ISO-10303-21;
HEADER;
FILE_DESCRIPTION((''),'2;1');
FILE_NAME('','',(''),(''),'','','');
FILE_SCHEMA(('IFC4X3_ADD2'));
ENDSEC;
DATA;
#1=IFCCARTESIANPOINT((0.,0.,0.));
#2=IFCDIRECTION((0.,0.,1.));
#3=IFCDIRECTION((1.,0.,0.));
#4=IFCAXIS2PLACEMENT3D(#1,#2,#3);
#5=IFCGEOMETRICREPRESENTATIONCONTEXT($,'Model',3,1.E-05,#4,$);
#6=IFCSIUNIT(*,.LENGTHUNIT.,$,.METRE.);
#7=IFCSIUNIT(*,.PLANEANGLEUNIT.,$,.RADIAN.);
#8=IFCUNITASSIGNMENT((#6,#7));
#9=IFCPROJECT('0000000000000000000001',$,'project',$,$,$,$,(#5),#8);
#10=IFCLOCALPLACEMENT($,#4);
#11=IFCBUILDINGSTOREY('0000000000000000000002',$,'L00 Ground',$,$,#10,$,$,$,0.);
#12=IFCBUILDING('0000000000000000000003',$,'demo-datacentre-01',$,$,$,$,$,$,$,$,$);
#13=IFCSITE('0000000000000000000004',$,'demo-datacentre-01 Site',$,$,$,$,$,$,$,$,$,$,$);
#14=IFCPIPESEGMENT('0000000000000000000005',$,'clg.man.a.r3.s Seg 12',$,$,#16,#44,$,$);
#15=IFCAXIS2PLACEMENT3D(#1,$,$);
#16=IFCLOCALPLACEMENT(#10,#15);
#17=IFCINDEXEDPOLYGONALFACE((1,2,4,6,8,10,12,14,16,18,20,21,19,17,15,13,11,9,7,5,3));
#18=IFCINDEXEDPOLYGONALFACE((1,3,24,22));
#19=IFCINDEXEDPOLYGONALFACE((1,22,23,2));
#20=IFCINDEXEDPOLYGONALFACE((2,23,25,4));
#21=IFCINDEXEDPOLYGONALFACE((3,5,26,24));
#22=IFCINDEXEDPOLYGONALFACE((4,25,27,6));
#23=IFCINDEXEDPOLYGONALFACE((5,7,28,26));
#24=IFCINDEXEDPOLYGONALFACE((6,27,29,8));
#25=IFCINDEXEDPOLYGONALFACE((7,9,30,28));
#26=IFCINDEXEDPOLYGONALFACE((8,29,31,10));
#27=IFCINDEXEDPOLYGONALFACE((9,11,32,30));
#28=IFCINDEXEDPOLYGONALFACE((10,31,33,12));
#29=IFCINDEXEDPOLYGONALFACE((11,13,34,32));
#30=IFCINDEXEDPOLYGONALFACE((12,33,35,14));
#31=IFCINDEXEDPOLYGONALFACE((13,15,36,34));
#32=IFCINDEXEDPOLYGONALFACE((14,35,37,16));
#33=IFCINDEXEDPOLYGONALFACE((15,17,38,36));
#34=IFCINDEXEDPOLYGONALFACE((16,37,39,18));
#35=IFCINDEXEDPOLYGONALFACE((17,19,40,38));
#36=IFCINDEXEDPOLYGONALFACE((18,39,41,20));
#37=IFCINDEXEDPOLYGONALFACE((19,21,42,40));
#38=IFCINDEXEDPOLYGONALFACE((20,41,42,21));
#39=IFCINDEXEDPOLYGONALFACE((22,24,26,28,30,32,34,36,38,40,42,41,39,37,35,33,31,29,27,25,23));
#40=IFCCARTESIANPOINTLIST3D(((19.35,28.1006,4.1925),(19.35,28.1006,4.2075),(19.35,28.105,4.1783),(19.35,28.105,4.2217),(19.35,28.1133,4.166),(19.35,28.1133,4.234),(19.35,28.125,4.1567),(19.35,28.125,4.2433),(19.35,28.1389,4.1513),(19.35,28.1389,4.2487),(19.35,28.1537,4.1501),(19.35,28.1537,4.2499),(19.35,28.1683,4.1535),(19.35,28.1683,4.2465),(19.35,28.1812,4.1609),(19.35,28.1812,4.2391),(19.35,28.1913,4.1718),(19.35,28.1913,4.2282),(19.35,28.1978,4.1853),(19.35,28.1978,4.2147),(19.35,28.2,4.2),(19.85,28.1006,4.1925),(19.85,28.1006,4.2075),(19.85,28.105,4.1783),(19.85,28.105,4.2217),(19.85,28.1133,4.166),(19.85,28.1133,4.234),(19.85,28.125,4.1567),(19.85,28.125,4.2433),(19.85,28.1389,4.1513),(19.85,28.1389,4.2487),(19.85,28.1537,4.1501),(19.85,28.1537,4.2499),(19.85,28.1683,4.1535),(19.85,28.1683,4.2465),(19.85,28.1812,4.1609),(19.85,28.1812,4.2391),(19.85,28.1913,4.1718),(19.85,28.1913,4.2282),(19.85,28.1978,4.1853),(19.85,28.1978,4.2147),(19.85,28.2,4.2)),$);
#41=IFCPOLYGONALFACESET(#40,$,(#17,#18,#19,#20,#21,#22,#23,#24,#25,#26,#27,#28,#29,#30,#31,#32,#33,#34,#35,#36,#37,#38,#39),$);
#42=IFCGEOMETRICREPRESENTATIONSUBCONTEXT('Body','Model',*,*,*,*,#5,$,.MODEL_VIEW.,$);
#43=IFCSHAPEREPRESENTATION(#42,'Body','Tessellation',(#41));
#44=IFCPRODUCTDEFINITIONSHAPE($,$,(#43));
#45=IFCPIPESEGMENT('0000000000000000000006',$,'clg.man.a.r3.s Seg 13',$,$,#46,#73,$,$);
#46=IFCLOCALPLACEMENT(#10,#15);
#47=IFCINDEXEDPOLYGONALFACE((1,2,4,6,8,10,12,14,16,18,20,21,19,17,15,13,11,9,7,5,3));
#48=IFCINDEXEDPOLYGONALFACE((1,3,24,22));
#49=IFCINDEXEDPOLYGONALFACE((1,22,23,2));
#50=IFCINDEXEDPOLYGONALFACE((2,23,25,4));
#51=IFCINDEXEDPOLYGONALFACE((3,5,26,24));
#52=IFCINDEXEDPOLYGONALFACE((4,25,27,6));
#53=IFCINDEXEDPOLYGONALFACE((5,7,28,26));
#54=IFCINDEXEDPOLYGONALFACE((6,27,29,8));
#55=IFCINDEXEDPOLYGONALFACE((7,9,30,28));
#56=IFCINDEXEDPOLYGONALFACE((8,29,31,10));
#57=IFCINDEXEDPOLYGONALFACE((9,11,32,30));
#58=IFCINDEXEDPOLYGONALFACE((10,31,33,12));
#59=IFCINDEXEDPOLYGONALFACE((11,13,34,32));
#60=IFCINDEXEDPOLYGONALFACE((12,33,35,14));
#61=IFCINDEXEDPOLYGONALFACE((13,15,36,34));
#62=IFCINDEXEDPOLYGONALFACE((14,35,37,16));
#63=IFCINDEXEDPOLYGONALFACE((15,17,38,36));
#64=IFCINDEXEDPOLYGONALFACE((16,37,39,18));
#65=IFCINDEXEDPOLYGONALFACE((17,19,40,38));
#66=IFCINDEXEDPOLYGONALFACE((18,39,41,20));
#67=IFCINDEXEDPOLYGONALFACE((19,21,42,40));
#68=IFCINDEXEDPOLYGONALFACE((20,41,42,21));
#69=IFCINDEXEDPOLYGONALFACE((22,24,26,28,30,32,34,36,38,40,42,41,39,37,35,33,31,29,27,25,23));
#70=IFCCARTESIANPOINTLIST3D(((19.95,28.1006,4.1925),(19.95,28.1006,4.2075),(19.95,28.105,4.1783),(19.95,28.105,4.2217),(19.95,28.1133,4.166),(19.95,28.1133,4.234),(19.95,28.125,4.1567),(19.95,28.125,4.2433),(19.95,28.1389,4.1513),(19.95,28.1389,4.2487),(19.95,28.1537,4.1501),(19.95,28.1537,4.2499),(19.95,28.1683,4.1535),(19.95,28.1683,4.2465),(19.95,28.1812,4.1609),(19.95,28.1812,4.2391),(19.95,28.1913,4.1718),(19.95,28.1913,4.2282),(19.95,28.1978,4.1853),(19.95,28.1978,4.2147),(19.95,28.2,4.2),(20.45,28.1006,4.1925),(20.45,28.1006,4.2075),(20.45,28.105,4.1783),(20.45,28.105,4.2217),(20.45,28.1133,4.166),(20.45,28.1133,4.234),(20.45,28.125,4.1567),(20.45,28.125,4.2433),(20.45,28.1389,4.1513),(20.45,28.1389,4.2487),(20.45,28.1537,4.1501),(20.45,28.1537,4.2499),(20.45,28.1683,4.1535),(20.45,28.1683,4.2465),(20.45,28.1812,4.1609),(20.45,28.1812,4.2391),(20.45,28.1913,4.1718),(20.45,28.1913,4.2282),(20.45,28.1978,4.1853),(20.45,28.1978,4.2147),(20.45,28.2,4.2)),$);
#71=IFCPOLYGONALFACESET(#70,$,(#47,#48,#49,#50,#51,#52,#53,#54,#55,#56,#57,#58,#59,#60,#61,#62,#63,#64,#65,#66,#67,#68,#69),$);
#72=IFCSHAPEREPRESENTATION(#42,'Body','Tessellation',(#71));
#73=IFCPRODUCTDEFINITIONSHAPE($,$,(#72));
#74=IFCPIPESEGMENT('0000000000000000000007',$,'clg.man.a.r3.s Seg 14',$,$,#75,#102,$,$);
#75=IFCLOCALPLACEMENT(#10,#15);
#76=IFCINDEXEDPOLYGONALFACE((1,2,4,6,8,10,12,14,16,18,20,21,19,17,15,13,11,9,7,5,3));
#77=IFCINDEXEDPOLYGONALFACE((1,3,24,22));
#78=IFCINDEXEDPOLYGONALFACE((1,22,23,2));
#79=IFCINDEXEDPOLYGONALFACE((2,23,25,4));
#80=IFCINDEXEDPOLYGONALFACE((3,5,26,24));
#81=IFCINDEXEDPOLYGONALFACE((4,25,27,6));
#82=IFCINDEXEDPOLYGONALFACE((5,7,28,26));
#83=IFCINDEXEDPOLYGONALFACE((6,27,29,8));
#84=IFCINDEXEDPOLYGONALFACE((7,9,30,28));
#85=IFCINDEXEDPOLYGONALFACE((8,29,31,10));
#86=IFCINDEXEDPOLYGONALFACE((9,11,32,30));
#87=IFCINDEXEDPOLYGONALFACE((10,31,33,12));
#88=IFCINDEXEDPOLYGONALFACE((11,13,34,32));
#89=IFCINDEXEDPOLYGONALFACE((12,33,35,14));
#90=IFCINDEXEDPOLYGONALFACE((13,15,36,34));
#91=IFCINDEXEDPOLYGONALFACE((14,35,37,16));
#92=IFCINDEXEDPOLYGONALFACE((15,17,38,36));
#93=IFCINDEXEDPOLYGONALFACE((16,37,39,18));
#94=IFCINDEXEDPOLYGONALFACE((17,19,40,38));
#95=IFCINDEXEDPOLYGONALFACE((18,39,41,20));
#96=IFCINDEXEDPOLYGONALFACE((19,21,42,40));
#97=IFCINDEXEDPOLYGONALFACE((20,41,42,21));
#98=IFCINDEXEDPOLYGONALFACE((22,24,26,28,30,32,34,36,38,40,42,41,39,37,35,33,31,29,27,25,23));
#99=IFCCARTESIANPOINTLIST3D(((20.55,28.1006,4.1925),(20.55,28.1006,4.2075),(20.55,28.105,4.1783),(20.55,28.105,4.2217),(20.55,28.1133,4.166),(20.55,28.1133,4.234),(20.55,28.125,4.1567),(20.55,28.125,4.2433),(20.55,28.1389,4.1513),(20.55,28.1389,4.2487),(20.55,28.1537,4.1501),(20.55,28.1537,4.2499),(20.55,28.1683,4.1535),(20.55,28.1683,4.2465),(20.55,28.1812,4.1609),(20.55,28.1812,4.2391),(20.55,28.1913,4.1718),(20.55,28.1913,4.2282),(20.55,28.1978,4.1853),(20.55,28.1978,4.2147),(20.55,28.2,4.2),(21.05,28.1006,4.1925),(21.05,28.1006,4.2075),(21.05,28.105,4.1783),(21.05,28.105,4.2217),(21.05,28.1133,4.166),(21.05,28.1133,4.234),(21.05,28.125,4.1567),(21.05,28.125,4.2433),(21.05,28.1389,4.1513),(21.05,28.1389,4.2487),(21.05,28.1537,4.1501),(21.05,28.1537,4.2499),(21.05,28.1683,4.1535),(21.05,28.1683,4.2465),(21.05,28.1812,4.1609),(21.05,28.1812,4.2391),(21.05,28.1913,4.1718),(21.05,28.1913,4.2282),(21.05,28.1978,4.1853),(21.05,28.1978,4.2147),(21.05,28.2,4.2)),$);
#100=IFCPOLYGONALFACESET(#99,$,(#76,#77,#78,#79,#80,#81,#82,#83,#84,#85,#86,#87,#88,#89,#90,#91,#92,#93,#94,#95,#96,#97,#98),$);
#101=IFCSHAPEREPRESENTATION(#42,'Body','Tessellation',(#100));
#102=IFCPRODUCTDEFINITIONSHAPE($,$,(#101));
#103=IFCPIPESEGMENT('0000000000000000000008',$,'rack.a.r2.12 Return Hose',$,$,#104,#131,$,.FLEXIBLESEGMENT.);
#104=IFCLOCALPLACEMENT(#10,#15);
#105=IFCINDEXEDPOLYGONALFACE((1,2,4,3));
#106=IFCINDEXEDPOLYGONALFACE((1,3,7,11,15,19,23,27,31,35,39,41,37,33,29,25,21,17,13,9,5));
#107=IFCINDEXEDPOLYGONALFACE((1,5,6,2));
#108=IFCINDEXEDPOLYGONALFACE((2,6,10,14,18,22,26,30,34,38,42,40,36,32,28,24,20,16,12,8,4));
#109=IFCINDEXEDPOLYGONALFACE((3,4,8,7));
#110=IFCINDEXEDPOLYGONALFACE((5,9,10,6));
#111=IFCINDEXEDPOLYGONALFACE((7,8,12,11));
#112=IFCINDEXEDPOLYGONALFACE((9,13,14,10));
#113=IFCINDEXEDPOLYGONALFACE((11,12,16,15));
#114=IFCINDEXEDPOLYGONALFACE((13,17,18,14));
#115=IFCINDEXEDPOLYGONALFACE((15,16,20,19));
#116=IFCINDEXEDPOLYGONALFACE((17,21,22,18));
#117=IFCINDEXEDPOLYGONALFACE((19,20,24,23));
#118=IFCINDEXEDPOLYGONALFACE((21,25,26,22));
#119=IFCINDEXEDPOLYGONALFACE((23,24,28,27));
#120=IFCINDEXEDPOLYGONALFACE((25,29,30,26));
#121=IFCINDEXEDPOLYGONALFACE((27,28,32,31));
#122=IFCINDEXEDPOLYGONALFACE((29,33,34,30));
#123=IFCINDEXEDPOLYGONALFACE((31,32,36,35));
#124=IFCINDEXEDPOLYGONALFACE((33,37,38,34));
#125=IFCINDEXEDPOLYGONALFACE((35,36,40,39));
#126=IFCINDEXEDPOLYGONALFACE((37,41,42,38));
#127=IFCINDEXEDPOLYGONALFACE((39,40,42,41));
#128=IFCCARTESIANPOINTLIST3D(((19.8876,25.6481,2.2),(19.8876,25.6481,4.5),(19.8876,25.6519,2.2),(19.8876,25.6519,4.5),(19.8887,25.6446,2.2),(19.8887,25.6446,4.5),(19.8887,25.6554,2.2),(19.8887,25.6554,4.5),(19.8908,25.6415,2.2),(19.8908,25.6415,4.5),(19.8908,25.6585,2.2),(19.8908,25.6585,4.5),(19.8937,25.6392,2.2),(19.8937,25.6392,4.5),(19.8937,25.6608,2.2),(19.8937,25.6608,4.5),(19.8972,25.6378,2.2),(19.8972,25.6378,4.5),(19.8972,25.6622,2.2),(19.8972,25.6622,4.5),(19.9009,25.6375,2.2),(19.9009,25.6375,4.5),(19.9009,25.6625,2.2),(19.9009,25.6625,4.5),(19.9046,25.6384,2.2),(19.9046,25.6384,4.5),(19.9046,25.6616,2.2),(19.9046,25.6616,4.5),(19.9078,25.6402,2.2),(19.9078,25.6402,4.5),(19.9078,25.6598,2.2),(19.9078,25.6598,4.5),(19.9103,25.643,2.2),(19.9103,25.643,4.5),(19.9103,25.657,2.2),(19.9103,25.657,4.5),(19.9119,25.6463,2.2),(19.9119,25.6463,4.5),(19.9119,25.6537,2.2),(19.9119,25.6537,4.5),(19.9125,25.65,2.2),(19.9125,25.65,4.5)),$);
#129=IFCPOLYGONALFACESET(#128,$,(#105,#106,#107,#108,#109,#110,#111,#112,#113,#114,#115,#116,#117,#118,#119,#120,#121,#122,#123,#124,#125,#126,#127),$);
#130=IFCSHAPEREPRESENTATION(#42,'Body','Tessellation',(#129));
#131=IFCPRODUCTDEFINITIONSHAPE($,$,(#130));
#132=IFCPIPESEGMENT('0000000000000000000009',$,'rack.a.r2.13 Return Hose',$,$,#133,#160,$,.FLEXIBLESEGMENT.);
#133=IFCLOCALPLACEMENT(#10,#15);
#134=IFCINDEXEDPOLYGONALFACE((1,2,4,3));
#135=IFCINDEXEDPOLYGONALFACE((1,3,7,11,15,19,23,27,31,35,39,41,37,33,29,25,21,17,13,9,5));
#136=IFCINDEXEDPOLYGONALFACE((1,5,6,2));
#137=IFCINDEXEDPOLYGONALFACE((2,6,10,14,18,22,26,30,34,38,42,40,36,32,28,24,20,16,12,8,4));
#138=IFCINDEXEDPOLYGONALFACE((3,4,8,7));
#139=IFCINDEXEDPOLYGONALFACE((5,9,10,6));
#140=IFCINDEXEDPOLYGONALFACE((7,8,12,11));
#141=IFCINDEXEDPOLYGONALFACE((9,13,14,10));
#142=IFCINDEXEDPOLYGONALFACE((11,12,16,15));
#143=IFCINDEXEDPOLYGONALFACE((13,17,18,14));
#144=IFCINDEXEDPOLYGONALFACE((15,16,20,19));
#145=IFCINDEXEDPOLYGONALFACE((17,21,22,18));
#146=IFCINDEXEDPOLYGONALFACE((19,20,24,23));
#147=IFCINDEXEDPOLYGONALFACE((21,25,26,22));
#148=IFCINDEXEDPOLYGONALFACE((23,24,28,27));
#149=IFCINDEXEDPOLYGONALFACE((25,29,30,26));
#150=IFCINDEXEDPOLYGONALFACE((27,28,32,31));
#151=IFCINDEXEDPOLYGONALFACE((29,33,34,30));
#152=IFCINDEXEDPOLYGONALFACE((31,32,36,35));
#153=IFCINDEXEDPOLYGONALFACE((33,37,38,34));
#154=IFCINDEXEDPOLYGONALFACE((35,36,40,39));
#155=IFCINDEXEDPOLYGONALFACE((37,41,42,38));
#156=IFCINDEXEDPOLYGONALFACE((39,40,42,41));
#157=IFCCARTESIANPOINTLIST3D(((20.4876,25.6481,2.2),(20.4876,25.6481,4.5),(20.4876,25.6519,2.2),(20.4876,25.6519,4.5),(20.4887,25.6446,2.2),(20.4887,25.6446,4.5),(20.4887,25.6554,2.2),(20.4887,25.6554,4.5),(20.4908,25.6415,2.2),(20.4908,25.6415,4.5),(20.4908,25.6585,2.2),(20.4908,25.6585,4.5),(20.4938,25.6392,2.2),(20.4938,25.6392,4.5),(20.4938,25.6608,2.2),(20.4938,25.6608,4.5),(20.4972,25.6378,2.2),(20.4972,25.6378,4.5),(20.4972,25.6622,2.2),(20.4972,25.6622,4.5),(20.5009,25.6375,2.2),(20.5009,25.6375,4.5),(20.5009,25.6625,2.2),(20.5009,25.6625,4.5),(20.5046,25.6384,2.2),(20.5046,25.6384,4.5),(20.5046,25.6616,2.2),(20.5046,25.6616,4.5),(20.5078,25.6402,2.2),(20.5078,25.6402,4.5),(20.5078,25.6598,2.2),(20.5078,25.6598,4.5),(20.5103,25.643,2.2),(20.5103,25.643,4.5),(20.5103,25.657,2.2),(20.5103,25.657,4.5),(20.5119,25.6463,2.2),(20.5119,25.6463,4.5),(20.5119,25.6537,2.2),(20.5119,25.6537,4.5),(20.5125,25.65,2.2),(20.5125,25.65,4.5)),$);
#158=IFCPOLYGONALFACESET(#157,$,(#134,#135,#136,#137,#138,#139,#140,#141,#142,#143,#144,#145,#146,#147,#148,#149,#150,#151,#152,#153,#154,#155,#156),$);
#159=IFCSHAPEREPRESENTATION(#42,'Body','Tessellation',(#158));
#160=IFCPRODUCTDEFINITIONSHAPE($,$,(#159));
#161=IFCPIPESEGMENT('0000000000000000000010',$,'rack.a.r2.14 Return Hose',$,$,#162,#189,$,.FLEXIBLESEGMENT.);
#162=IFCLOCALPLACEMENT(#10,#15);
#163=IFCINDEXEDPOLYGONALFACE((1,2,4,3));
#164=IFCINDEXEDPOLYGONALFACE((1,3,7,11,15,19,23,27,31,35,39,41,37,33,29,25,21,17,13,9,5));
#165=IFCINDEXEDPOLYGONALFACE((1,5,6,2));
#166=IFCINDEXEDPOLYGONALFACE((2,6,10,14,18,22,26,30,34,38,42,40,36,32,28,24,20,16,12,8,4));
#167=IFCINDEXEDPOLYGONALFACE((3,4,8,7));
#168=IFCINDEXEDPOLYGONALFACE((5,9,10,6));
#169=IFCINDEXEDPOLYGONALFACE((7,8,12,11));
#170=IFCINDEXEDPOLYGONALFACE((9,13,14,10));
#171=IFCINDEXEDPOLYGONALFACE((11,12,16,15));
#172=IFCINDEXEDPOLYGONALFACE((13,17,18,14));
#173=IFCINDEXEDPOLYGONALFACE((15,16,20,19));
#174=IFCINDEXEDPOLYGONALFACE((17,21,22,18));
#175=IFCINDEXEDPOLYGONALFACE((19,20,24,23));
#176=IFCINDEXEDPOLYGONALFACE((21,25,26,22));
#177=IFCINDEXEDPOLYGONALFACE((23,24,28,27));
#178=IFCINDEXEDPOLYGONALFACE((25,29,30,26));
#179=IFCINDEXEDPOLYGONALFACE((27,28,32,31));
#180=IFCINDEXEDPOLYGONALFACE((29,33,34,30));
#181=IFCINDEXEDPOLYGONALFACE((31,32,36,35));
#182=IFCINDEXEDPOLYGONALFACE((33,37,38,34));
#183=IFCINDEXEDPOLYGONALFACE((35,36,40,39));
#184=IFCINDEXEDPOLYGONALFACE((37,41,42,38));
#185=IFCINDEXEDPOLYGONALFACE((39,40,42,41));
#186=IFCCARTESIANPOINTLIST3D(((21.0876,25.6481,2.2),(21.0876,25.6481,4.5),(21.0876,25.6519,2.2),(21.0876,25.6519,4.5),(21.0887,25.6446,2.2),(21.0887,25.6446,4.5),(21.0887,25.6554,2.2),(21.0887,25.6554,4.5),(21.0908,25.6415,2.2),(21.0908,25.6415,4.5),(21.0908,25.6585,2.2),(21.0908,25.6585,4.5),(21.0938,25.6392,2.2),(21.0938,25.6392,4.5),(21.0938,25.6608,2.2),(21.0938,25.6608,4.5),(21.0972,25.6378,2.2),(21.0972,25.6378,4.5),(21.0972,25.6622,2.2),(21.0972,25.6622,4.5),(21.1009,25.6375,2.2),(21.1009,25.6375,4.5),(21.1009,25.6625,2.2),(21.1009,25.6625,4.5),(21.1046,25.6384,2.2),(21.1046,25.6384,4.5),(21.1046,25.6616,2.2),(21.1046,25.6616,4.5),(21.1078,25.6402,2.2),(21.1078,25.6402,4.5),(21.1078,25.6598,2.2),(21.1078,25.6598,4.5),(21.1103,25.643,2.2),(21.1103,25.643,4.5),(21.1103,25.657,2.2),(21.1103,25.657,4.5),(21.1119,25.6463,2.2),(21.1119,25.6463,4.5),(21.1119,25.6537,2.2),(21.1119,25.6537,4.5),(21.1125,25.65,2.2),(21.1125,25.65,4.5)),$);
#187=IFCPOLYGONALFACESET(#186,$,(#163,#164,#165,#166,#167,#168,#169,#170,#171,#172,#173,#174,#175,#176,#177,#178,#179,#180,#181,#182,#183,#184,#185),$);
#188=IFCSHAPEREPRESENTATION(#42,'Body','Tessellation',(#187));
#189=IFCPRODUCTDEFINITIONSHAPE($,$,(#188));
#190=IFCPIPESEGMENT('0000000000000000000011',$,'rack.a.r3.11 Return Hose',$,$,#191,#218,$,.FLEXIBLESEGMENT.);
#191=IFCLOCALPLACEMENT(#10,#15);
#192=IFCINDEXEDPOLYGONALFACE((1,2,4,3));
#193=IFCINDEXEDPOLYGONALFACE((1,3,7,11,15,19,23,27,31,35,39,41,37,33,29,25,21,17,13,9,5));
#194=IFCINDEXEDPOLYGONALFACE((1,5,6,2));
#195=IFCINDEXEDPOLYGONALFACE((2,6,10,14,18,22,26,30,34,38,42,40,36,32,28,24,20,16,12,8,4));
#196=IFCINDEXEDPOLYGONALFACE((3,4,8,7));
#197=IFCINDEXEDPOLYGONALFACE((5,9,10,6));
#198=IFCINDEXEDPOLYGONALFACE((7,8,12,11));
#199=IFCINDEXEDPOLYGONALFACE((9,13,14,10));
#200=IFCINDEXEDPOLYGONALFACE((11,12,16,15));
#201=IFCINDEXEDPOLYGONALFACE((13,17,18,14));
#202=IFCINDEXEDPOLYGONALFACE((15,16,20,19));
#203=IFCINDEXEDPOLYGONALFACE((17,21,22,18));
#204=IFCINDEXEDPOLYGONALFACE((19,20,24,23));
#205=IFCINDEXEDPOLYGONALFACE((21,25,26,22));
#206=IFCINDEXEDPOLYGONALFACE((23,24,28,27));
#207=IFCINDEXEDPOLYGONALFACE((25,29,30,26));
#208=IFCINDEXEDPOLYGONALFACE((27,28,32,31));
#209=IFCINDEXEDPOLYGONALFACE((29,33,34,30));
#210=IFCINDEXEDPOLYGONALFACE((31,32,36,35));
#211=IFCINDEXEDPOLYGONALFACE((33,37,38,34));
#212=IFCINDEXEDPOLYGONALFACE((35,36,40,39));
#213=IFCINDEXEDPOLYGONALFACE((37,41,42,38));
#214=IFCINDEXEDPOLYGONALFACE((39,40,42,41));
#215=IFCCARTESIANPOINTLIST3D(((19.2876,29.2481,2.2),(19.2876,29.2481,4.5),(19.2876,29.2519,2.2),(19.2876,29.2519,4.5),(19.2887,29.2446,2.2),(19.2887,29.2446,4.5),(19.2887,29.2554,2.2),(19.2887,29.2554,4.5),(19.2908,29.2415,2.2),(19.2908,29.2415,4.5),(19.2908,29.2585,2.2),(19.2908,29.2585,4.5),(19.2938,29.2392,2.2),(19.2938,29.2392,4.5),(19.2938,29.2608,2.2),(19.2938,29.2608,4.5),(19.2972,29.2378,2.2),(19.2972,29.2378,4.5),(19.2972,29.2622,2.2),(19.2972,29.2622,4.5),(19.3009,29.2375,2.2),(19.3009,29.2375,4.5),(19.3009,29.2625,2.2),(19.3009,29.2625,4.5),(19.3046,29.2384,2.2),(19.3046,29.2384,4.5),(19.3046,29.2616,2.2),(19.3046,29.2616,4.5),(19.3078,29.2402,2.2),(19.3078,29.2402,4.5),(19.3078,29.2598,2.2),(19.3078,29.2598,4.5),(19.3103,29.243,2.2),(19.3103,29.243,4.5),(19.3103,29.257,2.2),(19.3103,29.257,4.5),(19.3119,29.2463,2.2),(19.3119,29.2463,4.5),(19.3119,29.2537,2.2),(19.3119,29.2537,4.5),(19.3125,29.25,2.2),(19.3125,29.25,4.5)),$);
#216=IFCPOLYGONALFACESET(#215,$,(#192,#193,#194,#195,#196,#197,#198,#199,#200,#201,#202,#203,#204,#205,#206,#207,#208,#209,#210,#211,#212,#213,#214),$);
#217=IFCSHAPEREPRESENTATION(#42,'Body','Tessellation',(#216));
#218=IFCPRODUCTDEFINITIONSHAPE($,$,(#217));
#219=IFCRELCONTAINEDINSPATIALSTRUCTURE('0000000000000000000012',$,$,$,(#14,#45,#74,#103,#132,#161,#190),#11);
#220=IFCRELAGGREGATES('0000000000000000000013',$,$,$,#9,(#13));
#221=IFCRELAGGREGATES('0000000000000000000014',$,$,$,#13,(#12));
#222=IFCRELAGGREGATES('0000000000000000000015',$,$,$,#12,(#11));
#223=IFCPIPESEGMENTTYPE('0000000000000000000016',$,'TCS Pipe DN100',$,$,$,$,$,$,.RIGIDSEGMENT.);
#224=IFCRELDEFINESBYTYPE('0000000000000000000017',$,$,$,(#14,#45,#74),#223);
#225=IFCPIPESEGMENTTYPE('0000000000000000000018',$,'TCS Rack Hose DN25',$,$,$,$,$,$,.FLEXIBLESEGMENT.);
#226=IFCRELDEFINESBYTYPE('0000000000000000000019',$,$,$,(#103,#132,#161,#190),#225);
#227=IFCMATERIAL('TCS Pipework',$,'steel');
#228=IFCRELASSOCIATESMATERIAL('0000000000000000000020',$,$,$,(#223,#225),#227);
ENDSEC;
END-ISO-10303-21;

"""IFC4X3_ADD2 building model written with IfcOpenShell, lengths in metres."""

from ifc_helpers import new_model, si_unit, frame, origin_with_axes, place, context, subcontext, project, spatial, circle, extrude, material, type_object, element, save


model = new_model("IFC4X3_ADD2")

# Units and contexts
model_context = context("Model", 3, precision=1e-05, world=origin_with_axes())
body_context = subcontext(model_context, "Body", "Model", "MODEL_VIEW")
ifc_project = project(units=[si_unit("LENGTHUNIT", "METRE"), si_unit("PLANEANGLEUNIT", "RADIAN")], contexts=[model_context])

# Site, building, storey
site = spatial("IfcSite", under=ifc_project, Name="demo-datacentre-01 Site")
building = spatial("IfcBuilding", under=site, Name="demo-datacentre-01")
storey_placement = place(None, origin_with_axes())
storey = spatial("IfcBuildingStorey", under=building, at=storey_placement, Name="L00 Ground", Elevation=0.0)

# Shared definitions
ifc_material = material(Name="TCS Pipework", Category="steel")

# Pipe segments
pipe_segment_type_1 = type_object("IfcPipeSegmentType", Name="TCS Pipe DN100", PredefinedType="RIGIDSEGMENT", material=ifc_material)
for number, where, z_axis, x_axis, name in (
    (1, (19.35, 28.15, 4.2), (1.0, 0.0, 0.0), (0.0, 1.0, 0.0), "clg.man.a.r3.s Seg 12"),
):
    element("IfcPipeSegment", number, at=place(storey_placement, frame(where, z_axis=z_axis, x_axis=x_axis)), inside=storey, type_object=pipe_segment_type_1, Name=name, context=body_context, shape_type="SweptSolid", body=[
        extrude(circle(Radius=0.05), origin_with_axes(), (0.0, 0.0, 1.0), 0.5),
    ])
for number, where, z_axis, x_axis, name in (
    (2, (19.95, 28.15, 4.2), (1.0, 0.0, 0.0), (0.0, 1.0, 0.0), "clg.man.a.r3.s Seg 13"),
    (3, (20.55, 28.15, 4.2), (1.0, 0.0, 0.0), (0.0, 1.0, 0.0), "clg.man.a.r3.s Seg 14"),
):
    element("IfcPipeSegment", number, at=place(storey_placement, frame(where, z_axis=z_axis, x_axis=x_axis)), inside=storey, type_object=pipe_segment_type_1, Name=name, context=body_context, shape_type="SweptSolid", body=[
        extrude(circle(Radius=0.05), origin_with_axes(), (0.0, 0.0, 1.0), 0.5),
    ])
pipe_segment_type_2 = type_object("IfcPipeSegmentType", Name="TCS Rack Hose DN25", PredefinedType="FLEXIBLESEGMENT", material=ifc_material)
for number, where, z_axis, x_axis, name in (
    (4, (19.9, 25.65, 4.5), (0.0, 0.0, -1.0), (1.0, 0.0, 0.0), "rack.a.r2.12 Return Hose"),
    (5, (20.5, 25.65, 4.5), (0.0, 0.0, -1.0), (1.0, 0.0, 0.0), "rack.a.r2.13 Return Hose"),
    (6, (21.1, 25.65, 4.5), (0.0, 0.0, -1.0), (1.0, 0.0, 0.0), "rack.a.r2.14 Return Hose"),
    (7, (19.3, 29.25, 4.5), (0.0, 0.0, -1.0), (1.0, 0.0, 0.0), "rack.a.r3.11 Return Hose"),
):
    element("IfcPipeSegment", number, at=place(storey_placement, frame(where, z_axis=z_axis, x_axis=x_axis)), inside=storey, type_object=pipe_segment_type_2, Name=name, PredefinedType="FLEXIBLESEGMENT", context=body_context, shape_type="SweptSolid", body=[
        extrude(circle(Radius=0.0125), origin_with_axes(), (0.0, 0.0, 1.0), 2.3),
    ])

save(model, "model.ifc")
